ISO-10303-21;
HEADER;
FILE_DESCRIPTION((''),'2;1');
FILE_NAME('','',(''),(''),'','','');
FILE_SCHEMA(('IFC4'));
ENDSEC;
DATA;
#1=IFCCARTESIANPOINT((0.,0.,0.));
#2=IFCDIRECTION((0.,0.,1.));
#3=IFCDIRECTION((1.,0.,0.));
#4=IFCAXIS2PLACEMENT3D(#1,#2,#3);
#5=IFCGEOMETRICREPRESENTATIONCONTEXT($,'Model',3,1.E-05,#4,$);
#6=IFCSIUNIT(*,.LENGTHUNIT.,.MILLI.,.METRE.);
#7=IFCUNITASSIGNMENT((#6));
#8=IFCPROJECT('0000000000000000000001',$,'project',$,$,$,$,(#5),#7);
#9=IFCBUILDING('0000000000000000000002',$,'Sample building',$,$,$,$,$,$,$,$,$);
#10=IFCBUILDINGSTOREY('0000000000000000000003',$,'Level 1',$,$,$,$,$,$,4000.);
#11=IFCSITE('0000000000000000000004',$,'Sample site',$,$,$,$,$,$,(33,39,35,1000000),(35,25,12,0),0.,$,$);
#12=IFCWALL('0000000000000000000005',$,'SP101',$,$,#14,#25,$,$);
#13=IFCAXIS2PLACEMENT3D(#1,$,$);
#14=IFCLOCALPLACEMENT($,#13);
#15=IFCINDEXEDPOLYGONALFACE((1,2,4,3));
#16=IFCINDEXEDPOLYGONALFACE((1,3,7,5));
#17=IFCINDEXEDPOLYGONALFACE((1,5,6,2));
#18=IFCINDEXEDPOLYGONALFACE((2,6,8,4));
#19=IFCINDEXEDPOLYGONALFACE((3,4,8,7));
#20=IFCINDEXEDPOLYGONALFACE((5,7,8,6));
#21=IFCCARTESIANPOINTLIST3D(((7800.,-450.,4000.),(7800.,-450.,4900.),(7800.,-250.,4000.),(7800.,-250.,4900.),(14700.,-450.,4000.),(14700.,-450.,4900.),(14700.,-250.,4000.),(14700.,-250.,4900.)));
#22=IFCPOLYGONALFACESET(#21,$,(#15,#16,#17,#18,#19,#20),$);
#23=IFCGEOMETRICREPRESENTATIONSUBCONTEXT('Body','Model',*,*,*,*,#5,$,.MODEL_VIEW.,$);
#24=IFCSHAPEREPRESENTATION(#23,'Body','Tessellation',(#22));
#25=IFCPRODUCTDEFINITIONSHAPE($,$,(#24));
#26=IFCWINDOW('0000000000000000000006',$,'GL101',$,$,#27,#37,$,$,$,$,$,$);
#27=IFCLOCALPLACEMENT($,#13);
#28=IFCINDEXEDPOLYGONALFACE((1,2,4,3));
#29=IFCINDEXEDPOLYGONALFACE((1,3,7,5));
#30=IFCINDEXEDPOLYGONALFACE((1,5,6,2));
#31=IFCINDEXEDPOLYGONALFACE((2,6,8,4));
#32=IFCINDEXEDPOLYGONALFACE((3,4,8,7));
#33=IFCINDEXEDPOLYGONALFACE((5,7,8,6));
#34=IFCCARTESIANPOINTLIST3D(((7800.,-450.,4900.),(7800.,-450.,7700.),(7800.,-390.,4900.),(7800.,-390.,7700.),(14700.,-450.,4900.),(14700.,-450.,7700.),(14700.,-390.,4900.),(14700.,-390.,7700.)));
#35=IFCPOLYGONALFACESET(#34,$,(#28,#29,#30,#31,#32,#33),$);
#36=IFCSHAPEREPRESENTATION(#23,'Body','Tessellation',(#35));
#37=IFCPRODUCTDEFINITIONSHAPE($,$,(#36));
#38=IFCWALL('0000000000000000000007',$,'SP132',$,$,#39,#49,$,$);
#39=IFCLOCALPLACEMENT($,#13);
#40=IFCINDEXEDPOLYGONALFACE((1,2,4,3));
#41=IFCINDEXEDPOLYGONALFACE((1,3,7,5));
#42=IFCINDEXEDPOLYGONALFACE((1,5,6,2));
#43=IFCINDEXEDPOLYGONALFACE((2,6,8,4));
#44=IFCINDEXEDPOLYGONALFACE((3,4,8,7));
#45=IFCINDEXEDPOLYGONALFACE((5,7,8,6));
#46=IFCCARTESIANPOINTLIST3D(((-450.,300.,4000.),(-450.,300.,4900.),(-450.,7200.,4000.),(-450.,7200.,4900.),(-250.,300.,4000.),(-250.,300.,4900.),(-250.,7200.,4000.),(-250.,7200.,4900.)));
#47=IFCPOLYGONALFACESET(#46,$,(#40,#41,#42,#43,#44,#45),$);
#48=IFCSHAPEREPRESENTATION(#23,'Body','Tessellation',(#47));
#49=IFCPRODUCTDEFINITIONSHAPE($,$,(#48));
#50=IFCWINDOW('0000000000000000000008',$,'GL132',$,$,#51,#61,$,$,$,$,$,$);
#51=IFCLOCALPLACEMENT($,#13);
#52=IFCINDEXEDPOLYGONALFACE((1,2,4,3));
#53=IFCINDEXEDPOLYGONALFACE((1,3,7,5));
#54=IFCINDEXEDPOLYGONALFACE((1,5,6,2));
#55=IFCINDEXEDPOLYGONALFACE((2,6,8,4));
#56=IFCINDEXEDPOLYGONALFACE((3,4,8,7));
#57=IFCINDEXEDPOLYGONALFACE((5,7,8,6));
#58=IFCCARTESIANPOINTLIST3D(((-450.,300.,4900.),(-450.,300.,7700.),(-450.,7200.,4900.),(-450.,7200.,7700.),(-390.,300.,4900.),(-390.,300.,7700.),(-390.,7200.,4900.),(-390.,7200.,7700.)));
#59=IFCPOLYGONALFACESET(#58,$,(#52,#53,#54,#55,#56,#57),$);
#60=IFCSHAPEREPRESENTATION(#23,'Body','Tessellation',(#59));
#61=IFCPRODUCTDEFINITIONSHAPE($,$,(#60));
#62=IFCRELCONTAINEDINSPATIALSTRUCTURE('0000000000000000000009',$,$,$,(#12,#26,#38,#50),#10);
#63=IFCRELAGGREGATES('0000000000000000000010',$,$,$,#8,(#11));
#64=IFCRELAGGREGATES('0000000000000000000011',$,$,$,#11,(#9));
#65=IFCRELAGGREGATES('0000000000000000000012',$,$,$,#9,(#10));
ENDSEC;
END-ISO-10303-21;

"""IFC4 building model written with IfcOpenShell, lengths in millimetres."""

from ifc_helpers import new_model, si_unit, frame, origin_with_axes, place, context, subcontext, project, spatial, indexed_curve, outline, extrude, element, save


model = new_model("IFC4")

# Units and contexts
model_context = context("Model", 3, precision=1e-05, world=origin_with_axes())
body_context = subcontext(model_context, "Body", "Model", "MODEL_VIEW")
ifc_project = project(units=[si_unit("LENGTHUNIT", "METRE", prefix="MILLI")], contexts=[model_context])

# Site, building, storey
site = spatial("IfcSite", under=ifc_project, Name="Sample site", RefLatitude=(33, 39, 35, 1000000), RefLongitude=(35, 25, 12, 0), RefElevation=0.0)
building = spatial("IfcBuilding", under=site, Name="Sample building")
storey = spatial("IfcBuildingStorey", under=building, Name="Level 1", Elevation=4000.0)

# Wall
wall_1_placement = place(None, frame((7800.0, -450.0, 4000.0), z_axis=(0.0, 0.0, 1.0), x_axis=(1.0, 0.0, 0.0)))
element("IfcWall", 1, at=wall_1_placement, inside=storey, Name="SP101", context=body_context, shape_type="SweptSolid", body=[
    extrude(outline(indexed_curve([(0.0, 0.0), (0.0, 200.0), (6900.0, 200.0), (6900.0, 0.0), (0.0, 0.0)], self_intersect=False)), origin_with_axes(), (0.0, 0.0, 1.0), 900.0),
])

# Window
window_1_placement = place(None, frame((7800.0, -450.0, 4900.0), z_axis=(0.0, 0.0, 1.0), x_axis=(1.0, 0.0, 0.0)))
element("IfcWindow", 2, at=window_1_placement, inside=storey, Name="GL101", context=body_context, shape_type="SweptSolid", body=[
    extrude(outline(indexed_curve([(0.0, 0.0), (0.0, 60.0), (6900.0, 60.0), (6900.0, 0.0), (0.0, 0.0)], self_intersect=False)), origin_with_axes(), (0.0, 0.0, 1.0), 2800.0),
])

# Wall
wall_2_placement = place(None, frame((-450.0, 7200.0, 4000.0), z_axis=(0.0, 0.0, 1.0), x_axis=(0.0, -1.0, 0.0)))
element("IfcWall", 3, at=wall_2_placement, inside=storey, Name="SP132", context=body_context, shape_type="SweptSolid", body=[
    extrude(outline(indexed_curve([(0.0, 0.0), (0.0, 200.0), (6900.0, 200.0), (6900.0, 0.0), (0.0, 0.0)], self_intersect=False)), origin_with_axes(), (0.0, 0.0, 1.0), 900.0),
])

# Window
window_2_placement = place(None, frame((-450.0, 7200.0, 4900.0), z_axis=(0.0, 0.0, 1.0), x_axis=(0.0, -1.0, 0.0)))
element("IfcWindow", 4, at=window_2_placement, inside=storey, Name="GL132", context=body_context, shape_type="SweptSolid", body=[
    extrude(outline(indexed_curve([(0.0, 0.0), (0.0, 60.0), (6900.0, 60.0), (6900.0, 0.0), (0.0, 0.0)], self_intersect=False)), origin_with_axes(), (0.0, 0.0, 1.0), 2800.0),
])

save(model, "model.ifc")
